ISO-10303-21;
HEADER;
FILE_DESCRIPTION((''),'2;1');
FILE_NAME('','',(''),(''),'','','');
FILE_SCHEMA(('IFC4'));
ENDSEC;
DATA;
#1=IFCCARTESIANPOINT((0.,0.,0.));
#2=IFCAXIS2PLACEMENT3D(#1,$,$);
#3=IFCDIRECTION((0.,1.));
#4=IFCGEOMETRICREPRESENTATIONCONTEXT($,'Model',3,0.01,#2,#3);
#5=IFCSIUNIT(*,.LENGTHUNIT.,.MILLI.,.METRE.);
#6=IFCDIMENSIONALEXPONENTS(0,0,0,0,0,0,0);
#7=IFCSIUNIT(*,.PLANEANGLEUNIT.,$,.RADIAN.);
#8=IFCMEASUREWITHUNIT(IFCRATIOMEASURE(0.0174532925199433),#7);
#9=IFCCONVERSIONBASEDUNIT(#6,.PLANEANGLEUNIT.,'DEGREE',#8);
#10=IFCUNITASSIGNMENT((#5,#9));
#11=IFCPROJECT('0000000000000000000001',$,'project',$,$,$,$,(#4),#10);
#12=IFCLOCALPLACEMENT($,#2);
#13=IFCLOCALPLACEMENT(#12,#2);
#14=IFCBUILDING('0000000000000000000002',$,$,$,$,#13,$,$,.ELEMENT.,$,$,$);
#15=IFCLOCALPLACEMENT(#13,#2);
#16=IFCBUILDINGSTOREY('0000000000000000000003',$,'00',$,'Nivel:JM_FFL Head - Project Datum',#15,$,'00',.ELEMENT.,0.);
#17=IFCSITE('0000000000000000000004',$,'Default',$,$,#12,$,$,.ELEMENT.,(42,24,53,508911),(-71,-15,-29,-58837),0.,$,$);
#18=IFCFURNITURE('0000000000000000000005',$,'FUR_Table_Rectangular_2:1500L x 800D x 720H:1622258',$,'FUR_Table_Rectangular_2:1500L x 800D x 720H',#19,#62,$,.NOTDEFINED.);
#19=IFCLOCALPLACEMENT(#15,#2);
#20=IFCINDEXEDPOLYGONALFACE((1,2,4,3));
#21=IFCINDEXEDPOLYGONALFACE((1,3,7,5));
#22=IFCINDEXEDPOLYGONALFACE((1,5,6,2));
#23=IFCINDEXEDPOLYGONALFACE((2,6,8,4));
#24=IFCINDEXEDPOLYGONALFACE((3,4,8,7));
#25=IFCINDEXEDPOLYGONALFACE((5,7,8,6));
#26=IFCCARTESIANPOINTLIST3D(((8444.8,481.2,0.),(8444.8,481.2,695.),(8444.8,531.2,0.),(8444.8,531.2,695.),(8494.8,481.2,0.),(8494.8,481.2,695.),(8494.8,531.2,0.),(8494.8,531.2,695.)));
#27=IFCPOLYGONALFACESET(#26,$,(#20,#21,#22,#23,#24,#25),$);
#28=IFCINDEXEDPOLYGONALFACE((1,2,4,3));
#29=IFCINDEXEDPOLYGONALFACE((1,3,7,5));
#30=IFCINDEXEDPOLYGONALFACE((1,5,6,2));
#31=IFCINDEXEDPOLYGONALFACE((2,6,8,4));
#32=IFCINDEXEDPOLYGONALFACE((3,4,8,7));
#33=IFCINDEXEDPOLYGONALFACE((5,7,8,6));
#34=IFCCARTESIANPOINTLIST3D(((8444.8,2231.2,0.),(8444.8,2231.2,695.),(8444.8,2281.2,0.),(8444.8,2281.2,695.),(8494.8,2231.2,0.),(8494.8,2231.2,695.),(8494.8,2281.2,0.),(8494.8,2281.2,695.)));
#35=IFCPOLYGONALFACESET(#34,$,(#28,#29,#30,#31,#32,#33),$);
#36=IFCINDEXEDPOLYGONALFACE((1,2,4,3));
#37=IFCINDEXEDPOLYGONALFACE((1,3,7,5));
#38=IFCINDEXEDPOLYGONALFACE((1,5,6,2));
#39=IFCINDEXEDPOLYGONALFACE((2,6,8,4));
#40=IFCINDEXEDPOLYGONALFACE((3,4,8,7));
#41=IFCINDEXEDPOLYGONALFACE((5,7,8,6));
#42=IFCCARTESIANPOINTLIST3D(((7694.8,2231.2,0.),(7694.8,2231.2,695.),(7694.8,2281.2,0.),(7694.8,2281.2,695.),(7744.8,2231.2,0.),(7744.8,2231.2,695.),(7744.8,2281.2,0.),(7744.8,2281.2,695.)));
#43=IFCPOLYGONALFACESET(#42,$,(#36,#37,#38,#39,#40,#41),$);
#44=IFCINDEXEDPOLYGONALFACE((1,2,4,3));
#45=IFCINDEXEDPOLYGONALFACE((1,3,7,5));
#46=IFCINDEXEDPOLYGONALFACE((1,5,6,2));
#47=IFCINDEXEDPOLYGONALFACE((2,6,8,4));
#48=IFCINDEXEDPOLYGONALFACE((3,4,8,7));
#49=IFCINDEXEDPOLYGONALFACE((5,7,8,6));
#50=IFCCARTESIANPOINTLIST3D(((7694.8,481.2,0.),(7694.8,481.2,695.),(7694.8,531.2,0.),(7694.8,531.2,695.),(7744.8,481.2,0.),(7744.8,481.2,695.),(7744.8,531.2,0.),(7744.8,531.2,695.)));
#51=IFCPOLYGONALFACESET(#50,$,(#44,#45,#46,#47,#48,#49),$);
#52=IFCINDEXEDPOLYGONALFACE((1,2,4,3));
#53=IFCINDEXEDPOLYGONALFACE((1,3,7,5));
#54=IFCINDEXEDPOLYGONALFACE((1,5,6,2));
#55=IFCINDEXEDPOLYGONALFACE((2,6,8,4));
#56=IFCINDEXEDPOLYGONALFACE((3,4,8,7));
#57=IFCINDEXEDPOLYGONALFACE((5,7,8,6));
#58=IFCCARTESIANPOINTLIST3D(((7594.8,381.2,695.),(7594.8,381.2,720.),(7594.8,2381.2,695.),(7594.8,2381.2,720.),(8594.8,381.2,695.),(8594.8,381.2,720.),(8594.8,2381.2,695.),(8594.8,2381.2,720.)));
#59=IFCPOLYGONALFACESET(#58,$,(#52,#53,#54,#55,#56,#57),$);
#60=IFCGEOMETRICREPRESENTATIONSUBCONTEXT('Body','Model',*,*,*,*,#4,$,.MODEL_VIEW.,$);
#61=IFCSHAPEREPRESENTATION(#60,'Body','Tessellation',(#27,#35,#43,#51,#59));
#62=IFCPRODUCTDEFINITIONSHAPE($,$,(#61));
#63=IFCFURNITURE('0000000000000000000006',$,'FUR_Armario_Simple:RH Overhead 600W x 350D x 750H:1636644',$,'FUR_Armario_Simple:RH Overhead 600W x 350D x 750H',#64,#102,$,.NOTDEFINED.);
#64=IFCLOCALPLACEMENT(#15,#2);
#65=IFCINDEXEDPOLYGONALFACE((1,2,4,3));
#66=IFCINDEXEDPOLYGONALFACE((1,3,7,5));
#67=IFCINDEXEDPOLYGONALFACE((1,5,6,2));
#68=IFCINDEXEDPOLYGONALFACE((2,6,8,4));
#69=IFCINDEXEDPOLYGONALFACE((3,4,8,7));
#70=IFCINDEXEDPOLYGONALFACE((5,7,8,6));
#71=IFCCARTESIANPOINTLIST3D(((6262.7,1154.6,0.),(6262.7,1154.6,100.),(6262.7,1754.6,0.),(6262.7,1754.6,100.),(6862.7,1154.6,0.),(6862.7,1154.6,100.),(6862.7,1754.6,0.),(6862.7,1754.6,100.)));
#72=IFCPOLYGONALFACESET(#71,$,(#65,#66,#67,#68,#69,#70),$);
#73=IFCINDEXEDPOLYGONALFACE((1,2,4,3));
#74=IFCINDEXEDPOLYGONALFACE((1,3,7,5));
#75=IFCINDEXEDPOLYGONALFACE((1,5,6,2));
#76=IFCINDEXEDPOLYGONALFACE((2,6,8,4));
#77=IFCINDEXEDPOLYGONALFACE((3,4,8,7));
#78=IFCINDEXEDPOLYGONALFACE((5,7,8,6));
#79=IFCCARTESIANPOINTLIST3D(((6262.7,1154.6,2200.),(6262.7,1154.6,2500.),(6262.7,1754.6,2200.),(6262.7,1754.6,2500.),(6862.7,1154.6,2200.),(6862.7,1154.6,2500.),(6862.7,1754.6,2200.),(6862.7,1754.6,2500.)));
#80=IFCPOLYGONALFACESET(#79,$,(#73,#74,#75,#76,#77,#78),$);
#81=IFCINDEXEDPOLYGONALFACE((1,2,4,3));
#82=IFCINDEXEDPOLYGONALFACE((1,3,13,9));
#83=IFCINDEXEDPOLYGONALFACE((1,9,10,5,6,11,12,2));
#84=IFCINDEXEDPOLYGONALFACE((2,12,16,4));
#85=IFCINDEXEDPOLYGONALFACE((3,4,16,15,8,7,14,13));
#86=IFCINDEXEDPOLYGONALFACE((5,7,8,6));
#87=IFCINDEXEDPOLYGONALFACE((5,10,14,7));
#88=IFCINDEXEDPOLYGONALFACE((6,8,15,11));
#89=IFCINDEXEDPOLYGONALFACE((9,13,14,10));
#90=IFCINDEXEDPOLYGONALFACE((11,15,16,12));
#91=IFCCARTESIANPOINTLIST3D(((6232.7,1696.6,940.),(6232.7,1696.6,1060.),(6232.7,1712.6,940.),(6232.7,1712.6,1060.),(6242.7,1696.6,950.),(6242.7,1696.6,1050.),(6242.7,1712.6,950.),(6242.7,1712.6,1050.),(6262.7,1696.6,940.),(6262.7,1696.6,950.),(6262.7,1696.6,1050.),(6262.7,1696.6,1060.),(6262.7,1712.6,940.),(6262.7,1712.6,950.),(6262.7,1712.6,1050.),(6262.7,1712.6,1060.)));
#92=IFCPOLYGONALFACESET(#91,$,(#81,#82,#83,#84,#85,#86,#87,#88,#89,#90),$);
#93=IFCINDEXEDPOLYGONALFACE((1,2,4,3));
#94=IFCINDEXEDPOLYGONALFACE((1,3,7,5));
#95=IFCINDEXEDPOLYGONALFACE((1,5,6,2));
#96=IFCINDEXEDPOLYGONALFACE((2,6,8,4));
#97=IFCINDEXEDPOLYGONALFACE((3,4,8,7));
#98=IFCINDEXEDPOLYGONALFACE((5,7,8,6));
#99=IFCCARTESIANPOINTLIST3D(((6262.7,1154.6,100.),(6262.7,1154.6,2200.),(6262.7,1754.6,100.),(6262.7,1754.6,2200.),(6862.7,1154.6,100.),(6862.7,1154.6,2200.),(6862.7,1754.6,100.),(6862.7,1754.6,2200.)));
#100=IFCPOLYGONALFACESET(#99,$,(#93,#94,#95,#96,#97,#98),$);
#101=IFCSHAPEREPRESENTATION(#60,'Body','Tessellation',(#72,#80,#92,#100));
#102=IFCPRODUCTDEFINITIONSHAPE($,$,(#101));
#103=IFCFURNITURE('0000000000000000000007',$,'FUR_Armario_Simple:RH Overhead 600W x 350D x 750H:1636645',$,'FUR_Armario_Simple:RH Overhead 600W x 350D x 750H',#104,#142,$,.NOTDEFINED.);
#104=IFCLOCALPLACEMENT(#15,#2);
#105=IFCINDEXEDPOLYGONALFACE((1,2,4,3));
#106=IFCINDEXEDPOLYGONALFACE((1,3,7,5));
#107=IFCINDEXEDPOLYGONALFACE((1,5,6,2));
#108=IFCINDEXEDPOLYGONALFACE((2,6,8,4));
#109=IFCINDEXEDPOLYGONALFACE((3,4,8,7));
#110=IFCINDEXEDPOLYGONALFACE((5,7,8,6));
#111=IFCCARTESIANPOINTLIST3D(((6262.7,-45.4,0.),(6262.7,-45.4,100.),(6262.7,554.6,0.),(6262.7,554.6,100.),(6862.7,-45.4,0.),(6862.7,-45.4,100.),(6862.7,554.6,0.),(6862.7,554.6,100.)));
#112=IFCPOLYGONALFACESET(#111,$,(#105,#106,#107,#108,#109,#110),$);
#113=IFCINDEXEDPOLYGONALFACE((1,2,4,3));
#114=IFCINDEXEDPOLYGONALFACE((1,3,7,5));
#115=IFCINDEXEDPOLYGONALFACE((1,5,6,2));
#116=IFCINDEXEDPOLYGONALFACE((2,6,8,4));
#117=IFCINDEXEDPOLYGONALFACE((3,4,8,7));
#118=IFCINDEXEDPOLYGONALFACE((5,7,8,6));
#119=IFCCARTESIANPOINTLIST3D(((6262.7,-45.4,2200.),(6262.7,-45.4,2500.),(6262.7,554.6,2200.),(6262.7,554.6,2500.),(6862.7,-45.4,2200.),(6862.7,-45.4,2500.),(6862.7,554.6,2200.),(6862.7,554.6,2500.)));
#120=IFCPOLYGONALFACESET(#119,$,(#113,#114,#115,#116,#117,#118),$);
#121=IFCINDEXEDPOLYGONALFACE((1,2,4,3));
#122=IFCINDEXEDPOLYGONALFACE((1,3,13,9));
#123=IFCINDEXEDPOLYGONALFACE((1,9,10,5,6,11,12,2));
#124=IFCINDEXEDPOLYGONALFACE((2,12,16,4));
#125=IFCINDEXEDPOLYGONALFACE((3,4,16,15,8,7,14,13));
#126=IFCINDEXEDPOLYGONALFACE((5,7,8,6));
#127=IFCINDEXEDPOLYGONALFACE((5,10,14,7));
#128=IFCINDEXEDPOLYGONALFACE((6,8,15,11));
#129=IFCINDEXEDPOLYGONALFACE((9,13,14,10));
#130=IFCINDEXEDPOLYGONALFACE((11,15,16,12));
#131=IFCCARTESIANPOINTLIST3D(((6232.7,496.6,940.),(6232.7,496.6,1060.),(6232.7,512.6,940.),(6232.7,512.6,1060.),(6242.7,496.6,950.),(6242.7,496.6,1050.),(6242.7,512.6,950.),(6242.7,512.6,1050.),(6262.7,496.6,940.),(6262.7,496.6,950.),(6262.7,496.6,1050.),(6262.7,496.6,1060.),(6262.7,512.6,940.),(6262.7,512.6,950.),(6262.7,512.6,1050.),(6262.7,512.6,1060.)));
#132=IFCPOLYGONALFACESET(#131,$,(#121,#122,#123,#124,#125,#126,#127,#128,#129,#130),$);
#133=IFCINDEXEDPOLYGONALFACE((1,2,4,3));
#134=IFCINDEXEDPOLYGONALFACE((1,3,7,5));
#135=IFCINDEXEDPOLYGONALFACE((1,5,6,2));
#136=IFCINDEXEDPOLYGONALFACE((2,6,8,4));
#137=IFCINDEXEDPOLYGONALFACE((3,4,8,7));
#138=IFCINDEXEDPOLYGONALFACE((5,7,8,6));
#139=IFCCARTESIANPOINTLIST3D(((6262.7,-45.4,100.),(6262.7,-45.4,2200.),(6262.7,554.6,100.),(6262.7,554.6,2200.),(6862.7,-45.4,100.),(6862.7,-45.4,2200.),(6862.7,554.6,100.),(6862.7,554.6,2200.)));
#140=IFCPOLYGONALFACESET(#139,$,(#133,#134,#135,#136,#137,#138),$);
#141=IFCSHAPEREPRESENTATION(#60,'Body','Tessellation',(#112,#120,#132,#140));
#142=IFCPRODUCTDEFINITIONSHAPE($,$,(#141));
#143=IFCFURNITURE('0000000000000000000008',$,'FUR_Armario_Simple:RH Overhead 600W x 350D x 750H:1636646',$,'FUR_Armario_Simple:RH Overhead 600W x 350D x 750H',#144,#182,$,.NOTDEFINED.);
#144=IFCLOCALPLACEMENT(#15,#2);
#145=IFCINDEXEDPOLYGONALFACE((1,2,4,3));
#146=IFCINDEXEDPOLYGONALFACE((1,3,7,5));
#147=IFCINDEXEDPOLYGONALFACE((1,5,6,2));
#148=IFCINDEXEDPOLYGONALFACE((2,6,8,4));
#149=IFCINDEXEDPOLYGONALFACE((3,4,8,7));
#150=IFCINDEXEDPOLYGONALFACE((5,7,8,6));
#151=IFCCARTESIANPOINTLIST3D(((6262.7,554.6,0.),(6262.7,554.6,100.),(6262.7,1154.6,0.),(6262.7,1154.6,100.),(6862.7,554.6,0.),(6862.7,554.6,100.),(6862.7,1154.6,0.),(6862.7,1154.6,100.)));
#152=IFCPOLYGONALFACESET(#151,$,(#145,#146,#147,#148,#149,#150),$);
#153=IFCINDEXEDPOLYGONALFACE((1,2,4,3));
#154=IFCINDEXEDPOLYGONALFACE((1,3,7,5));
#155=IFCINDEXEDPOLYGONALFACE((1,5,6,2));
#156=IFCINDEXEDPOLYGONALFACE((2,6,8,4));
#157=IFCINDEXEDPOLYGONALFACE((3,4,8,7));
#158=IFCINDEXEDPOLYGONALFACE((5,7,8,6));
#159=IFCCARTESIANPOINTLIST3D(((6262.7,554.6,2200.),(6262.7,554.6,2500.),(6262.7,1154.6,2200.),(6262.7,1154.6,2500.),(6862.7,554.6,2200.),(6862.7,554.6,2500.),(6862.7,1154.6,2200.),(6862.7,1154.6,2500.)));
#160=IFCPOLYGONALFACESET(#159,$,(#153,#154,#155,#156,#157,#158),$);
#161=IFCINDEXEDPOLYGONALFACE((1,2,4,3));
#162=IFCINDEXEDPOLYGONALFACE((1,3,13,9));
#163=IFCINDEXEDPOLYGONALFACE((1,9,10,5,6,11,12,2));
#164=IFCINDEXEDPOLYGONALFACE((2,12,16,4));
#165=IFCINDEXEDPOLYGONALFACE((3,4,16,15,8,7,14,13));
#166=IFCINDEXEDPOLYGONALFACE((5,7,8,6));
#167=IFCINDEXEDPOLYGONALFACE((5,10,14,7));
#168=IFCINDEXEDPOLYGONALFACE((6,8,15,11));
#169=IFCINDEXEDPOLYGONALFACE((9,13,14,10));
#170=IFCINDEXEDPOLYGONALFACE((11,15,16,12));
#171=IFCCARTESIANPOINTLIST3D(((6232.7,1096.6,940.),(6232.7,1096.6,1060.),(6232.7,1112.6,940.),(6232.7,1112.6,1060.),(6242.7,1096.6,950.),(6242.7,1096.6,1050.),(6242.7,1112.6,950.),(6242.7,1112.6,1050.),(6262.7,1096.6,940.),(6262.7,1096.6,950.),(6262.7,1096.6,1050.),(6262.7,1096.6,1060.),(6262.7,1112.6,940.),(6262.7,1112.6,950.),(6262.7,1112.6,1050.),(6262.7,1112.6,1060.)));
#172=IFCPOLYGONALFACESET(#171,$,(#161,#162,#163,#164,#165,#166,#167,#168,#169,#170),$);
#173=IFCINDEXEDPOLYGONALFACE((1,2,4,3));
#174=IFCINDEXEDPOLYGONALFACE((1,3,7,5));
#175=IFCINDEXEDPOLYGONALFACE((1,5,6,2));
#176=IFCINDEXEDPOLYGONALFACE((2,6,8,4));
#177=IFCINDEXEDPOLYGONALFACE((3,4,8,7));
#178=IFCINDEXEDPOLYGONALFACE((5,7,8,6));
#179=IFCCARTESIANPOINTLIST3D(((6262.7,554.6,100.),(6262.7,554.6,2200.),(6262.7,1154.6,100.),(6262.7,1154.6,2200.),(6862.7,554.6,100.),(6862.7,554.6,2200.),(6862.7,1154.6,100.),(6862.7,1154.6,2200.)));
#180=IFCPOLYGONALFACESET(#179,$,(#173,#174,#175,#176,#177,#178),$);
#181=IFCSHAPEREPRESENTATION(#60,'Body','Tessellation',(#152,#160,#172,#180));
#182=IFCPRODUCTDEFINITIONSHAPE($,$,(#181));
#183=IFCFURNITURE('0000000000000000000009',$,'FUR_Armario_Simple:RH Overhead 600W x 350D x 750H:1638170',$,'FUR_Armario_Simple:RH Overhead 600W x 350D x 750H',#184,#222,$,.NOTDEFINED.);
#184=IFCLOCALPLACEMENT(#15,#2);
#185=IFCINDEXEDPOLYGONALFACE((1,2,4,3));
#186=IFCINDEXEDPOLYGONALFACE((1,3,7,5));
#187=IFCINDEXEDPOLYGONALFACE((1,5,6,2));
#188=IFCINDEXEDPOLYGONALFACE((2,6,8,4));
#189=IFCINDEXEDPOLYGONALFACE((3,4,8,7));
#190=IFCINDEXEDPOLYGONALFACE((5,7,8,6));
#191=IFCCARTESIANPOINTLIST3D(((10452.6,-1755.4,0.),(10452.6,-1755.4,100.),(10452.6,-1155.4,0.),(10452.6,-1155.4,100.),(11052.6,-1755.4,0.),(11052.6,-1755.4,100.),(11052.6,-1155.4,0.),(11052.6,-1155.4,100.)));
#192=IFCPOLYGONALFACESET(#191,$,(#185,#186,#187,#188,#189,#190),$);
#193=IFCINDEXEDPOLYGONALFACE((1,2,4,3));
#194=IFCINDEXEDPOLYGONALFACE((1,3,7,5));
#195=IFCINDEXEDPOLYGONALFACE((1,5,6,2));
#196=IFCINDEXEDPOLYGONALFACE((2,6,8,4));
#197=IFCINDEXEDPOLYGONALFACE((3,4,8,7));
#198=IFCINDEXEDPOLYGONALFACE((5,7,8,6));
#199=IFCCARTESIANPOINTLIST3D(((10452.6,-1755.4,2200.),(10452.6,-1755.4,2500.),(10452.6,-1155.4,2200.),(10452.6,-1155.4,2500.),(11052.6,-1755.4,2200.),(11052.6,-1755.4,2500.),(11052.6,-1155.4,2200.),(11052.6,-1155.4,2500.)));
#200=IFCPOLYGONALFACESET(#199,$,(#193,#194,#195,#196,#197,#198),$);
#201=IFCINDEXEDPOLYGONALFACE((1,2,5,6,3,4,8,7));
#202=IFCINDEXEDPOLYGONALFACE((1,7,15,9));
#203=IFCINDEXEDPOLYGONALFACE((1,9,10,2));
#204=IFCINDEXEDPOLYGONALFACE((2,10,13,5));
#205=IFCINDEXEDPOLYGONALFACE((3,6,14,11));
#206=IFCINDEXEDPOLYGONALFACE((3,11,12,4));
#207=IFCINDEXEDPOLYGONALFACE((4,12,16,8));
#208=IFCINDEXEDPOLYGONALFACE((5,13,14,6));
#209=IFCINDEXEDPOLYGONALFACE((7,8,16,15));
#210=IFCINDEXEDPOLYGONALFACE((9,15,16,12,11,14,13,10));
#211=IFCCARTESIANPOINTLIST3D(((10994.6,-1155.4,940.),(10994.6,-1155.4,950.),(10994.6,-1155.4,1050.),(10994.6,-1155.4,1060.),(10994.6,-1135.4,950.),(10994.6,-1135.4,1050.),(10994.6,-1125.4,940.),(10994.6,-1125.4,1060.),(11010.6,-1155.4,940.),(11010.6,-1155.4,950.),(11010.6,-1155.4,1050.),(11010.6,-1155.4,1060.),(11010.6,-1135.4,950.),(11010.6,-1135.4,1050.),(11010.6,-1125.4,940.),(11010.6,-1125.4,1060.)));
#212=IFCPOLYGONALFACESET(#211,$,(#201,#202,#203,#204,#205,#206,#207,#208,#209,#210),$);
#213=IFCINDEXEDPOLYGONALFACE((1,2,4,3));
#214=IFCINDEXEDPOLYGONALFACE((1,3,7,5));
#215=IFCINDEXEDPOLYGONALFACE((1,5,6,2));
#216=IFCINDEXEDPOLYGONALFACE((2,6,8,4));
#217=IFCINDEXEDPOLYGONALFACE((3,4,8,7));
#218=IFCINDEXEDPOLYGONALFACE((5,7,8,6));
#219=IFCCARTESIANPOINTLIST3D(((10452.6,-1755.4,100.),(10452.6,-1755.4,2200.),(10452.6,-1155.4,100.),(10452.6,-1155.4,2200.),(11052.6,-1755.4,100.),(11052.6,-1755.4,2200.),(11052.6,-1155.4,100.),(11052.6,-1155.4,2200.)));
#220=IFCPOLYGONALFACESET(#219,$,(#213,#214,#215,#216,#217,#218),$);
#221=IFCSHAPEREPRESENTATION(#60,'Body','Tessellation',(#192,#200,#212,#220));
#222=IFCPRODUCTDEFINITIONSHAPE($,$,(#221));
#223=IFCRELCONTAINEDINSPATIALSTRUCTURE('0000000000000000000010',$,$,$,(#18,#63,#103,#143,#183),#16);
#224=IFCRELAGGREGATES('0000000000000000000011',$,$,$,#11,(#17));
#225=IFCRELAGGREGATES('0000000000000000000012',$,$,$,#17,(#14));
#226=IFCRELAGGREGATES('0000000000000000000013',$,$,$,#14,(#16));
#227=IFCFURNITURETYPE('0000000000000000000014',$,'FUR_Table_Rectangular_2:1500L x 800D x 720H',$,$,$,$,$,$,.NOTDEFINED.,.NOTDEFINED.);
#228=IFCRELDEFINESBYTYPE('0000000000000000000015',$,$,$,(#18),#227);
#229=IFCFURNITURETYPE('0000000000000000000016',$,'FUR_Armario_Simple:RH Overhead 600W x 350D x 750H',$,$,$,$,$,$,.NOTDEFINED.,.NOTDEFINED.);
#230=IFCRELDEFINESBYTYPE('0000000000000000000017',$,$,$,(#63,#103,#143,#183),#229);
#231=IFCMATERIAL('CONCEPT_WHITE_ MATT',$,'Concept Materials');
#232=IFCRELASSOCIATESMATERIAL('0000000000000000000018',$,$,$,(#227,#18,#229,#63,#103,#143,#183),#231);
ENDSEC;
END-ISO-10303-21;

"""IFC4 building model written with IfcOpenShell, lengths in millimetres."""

from ifc_helpers import new_model, entity, si_unit, converted_unit, direction, frame, origin, place, context, subcontext, project, spatial, indexed_curve, outline, extrude, source, transform, mapped, material, type_object, type_shapes, element, save


model = new_model("IFC4")

# Units and contexts
model_context = context("Model", 3, precision=0.01, world=origin(), true_north=direction((0.0, 1.0)))
body_context = subcontext(model_context, "Body", "Model", "MODEL_VIEW")
ifc_project = project(units=[si_unit("LENGTHUNIT", "METRE", prefix="MILLI"), converted_unit("PLANEANGLEUNIT", "DEGREE", entity("IfcRatioMeasure", 0.0174532925199433), si_unit("PLANEANGLEUNIT", "RADIAN"), dimensions=[0, 0, 0, 0, 0, 0, 0])], contexts=[model_context])

# Site, building, storey
site_placement = place(None, origin())
site = spatial("IfcSite", under=ifc_project, at=site_placement, Name="Default", CompositionType="ELEMENT", RefLatitude=(42, 24, 53, 508911), RefLongitude=(-71, -15, -29, -58837), RefElevation=0.0)
building_placement = place(site_placement, origin())
building = spatial("IfcBuilding", under=site, at=building_placement, CompositionType="ELEMENT")
storey_placement = place(building_placement, origin())
storey = spatial("IfcBuildingStorey", under=building, at=storey_placement, Name="00", ObjectType="Nivel:JM_FFL Head - Project Datum", LongName="00", CompositionType="ELEMENT", Elevation=0.0)

# Furniture
ifc_material_1 = material(Name="CONCEPT_WHITE_ MATT", Category="Concept Materials")
furniture_type_1 = type_object("IfcFurnitureType", Name="FUR_Table_Rectangular_2:1500L x 800D x 720H", AssemblyPlace="NOTDEFINED", PredefinedType="NOTDEFINED", material=ifc_material_1)
shared_shape_1 = source(origin(), body_context, "Body", "SweptSolid", [
    extrude(outline(indexed_curve([(-25.0, -25.0), (25.0, -25.0), (25.0, 25.0), (-25.0, 25.0), (-25.0, -25.0)], self_intersect=False)), frame((875.0, 375.0, 0.0), z_axis=(0.0, 0.0, 1.0), x_axis=(-1.0, 0.0, 0.0)), (0.0, 0.0, 1.0), 695.0),
    extrude(outline(indexed_curve([(-25.0, -25.0), (25.0, -25.0), (25.0, 25.0), (-25.0, 25.0), (-25.0, -25.0)], self_intersect=False)), frame((-875.0, 375.0, 0.0), z_axis=(0.0, 0.0, 1.0), x_axis=(-1.0, 0.0, 0.0)), (0.0, 0.0, 1.0), 695.0),
    extrude(outline(indexed_curve([(-25.0, -25.0), (25.0, -25.0), (25.0, 25.0), (-25.0, 25.0), (-25.0, -25.0)], self_intersect=False)), frame((-875.0, -375.0, 0.0), z_axis=(0.0, 0.0, 1.0), x_axis=(-1.0, 0.0, 0.0)), (0.0, 0.0, 1.0), 695.0),
    extrude(outline(indexed_curve([(-25.0, -25.0), (25.0, -25.0), (25.0, 25.0), (-25.0, 25.0), (-25.0, -25.0)], self_intersect=False)), frame((875.0, -375.0, 0.0), z_axis=(0.0, 0.0, 1.0), x_axis=(-1.0, 0.0, 0.0)), (0.0, 0.0, 1.0), 695.0),
    extrude(outline(indexed_curve([(-1000.0, -500.0), (1000.0, -500.0), (1000.0, 500.0), (-1000.0, 500.0), (-1000.0, -500.0)], self_intersect=False)), frame((0.0, 0.0, 695.0), z_axis=(0.0, 0.0, 1.0), x_axis=(-1.0, 0.0, 0.0)), (0.0, 0.0, 1.0), 25.0),
])
type_shapes(furniture_type_1, [shared_shape_1])
furniture_1_placement = place(storey_placement, frame((8094.8, 1381.2, 0.0), z_axis=(0.0, 0.0, 1.0), x_axis=(0.0, -1.0, 0.0)))
element("IfcFurniture", 1, at=furniture_1_placement, inside=storey, type_object=furniture_type_1, material=ifc_material_1, Name="FUR_Table_Rectangular_2:1500L x 800D x 720H:1622258", ObjectType="FUR_Table_Rectangular_2:1500L x 800D x 720H", PredefinedType="NOTDEFINED", context=body_context, shape_type="MappedRepresentation", body=[
    mapped(shared_shape_1, transform((0.0, 0.0, 0.0), scale=1.0)),
])
furniture_type_2 = type_object("IfcFurnitureType", Name="FUR_Armario_Simple:RH Overhead 600W x 350D x 750H", AssemblyPlace="NOTDEFINED", PredefinedType="NOTDEFINED", material=ifc_material_1)
shared_shape_2 = source(origin(), body_context, "Body", "SweptSolid", [
    extrude(outline(indexed_curve([(-300.0, -300.0), (300.0, -300.0), (300.0, 300.0), (-300.0, 300.0), (-300.0, -300.0)], self_intersect=False)), frame((300.0, 300.0, 0.0), z_axis=(0.0, 0.0, 1.0), x_axis=(0.0, 1.0, 0.0)), (0.0, 0.0, 1.0), 100.0),
    extrude(outline(indexed_curve([(-300.0, -300.0), (300.0, -300.0), (300.0, 300.0), (-300.0, 300.0), (-300.0, -300.0)], self_intersect=False)), frame((300.0, 300.0, 2200.0), z_axis=(0.0, 0.0, 1.0), x_axis=(0.0, 1.0, 0.0)), (0.0, 0.0, 1.0), 300.0),
    extrude(outline(indexed_curve([(-17.5, -60.0), (12.5, -60.0), (12.5, -50.0), (-7.5, -50.0), (-7.5, 50.0), (12.5, 50.0), (12.5, 60.0), (-17.5, 60.0), (-17.5, -60.0)], self_intersect=False)), frame((542.0, 612.5, 1000.0), z_axis=(1.0, 0.0, 0.0), x_axis=(0.0, -1.0, 0.0)), (0.0, 0.0, 1.0), 16.0),
    extrude(outline(indexed_curve([(-300.0, -300.0), (300.0, -300.0), (300.0, 300.0), (-300.0, 300.0), (-300.0, -300.0)], self_intersect=False)), frame((300.0, 300.0, 100.0), z_axis=(0.0, 0.0, 1.0), x_axis=(-1.0, 0.0, 0.0)), (0.0, 0.0, 1.0), 2100.0),
])
type_shapes(furniture_type_2, [shared_shape_2])
for number, where, z_axis, x_axis, name in (
    (2, (6862.7, 1154.6, 0.0), (0.0, 0.0, 1.0), (0.0, 1.0, 0.0), "FUR_Armario_Simple:RH Overhead 600W x 350D x 750H:1636644"),
    (3, (6862.7, -45.4, 0.0), (0.0, 0.0, 1.0), (0.0, 1.0, 0.0), "FUR_Armario_Simple:RH Overhead 600W x 350D x 750H:1636645"),
    (4, (6862.7, 554.6, 0.0), (0.0, 0.0, 1.0), (0.0, 1.0, 0.0), "FUR_Armario_Simple:RH Overhead 600W x 350D x 750H:1636646"),
):
    element("IfcFurniture", number, at=place(storey_placement, frame(where, z_axis=z_axis, x_axis=x_axis)), inside=storey, type_object=furniture_type_2, material=ifc_material_1, Name=name, ObjectType="FUR_Armario_Simple:RH Overhead 600W x 350D x 750H", PredefinedType="NOTDEFINED", context=body_context, shape_type="MappedRepresentation", body=[
        mapped(shared_shape_2, transform((0.0, 0.0, 0.0), scale=1.0)),
    ])
furniture_2_placement = place(storey_placement, frame((10452.6, -1755.4, 0.0)))
element("IfcFurniture", 5, at=furniture_2_placement, inside=storey, type_object=furniture_type_2, material=ifc_material_1, Name="FUR_Armario_Simple:RH Overhead 600W x 350D x 750H:1638170", ObjectType="FUR_Armario_Simple:RH Overhead 600W x 350D x 750H", PredefinedType="NOTDEFINED", context=body_context, shape_type="MappedRepresentation", body=[
    mapped(shared_shape_2, transform((0.0, 0.0, 0.0), scale=1.0)),
])

save(model, "model.ifc")
